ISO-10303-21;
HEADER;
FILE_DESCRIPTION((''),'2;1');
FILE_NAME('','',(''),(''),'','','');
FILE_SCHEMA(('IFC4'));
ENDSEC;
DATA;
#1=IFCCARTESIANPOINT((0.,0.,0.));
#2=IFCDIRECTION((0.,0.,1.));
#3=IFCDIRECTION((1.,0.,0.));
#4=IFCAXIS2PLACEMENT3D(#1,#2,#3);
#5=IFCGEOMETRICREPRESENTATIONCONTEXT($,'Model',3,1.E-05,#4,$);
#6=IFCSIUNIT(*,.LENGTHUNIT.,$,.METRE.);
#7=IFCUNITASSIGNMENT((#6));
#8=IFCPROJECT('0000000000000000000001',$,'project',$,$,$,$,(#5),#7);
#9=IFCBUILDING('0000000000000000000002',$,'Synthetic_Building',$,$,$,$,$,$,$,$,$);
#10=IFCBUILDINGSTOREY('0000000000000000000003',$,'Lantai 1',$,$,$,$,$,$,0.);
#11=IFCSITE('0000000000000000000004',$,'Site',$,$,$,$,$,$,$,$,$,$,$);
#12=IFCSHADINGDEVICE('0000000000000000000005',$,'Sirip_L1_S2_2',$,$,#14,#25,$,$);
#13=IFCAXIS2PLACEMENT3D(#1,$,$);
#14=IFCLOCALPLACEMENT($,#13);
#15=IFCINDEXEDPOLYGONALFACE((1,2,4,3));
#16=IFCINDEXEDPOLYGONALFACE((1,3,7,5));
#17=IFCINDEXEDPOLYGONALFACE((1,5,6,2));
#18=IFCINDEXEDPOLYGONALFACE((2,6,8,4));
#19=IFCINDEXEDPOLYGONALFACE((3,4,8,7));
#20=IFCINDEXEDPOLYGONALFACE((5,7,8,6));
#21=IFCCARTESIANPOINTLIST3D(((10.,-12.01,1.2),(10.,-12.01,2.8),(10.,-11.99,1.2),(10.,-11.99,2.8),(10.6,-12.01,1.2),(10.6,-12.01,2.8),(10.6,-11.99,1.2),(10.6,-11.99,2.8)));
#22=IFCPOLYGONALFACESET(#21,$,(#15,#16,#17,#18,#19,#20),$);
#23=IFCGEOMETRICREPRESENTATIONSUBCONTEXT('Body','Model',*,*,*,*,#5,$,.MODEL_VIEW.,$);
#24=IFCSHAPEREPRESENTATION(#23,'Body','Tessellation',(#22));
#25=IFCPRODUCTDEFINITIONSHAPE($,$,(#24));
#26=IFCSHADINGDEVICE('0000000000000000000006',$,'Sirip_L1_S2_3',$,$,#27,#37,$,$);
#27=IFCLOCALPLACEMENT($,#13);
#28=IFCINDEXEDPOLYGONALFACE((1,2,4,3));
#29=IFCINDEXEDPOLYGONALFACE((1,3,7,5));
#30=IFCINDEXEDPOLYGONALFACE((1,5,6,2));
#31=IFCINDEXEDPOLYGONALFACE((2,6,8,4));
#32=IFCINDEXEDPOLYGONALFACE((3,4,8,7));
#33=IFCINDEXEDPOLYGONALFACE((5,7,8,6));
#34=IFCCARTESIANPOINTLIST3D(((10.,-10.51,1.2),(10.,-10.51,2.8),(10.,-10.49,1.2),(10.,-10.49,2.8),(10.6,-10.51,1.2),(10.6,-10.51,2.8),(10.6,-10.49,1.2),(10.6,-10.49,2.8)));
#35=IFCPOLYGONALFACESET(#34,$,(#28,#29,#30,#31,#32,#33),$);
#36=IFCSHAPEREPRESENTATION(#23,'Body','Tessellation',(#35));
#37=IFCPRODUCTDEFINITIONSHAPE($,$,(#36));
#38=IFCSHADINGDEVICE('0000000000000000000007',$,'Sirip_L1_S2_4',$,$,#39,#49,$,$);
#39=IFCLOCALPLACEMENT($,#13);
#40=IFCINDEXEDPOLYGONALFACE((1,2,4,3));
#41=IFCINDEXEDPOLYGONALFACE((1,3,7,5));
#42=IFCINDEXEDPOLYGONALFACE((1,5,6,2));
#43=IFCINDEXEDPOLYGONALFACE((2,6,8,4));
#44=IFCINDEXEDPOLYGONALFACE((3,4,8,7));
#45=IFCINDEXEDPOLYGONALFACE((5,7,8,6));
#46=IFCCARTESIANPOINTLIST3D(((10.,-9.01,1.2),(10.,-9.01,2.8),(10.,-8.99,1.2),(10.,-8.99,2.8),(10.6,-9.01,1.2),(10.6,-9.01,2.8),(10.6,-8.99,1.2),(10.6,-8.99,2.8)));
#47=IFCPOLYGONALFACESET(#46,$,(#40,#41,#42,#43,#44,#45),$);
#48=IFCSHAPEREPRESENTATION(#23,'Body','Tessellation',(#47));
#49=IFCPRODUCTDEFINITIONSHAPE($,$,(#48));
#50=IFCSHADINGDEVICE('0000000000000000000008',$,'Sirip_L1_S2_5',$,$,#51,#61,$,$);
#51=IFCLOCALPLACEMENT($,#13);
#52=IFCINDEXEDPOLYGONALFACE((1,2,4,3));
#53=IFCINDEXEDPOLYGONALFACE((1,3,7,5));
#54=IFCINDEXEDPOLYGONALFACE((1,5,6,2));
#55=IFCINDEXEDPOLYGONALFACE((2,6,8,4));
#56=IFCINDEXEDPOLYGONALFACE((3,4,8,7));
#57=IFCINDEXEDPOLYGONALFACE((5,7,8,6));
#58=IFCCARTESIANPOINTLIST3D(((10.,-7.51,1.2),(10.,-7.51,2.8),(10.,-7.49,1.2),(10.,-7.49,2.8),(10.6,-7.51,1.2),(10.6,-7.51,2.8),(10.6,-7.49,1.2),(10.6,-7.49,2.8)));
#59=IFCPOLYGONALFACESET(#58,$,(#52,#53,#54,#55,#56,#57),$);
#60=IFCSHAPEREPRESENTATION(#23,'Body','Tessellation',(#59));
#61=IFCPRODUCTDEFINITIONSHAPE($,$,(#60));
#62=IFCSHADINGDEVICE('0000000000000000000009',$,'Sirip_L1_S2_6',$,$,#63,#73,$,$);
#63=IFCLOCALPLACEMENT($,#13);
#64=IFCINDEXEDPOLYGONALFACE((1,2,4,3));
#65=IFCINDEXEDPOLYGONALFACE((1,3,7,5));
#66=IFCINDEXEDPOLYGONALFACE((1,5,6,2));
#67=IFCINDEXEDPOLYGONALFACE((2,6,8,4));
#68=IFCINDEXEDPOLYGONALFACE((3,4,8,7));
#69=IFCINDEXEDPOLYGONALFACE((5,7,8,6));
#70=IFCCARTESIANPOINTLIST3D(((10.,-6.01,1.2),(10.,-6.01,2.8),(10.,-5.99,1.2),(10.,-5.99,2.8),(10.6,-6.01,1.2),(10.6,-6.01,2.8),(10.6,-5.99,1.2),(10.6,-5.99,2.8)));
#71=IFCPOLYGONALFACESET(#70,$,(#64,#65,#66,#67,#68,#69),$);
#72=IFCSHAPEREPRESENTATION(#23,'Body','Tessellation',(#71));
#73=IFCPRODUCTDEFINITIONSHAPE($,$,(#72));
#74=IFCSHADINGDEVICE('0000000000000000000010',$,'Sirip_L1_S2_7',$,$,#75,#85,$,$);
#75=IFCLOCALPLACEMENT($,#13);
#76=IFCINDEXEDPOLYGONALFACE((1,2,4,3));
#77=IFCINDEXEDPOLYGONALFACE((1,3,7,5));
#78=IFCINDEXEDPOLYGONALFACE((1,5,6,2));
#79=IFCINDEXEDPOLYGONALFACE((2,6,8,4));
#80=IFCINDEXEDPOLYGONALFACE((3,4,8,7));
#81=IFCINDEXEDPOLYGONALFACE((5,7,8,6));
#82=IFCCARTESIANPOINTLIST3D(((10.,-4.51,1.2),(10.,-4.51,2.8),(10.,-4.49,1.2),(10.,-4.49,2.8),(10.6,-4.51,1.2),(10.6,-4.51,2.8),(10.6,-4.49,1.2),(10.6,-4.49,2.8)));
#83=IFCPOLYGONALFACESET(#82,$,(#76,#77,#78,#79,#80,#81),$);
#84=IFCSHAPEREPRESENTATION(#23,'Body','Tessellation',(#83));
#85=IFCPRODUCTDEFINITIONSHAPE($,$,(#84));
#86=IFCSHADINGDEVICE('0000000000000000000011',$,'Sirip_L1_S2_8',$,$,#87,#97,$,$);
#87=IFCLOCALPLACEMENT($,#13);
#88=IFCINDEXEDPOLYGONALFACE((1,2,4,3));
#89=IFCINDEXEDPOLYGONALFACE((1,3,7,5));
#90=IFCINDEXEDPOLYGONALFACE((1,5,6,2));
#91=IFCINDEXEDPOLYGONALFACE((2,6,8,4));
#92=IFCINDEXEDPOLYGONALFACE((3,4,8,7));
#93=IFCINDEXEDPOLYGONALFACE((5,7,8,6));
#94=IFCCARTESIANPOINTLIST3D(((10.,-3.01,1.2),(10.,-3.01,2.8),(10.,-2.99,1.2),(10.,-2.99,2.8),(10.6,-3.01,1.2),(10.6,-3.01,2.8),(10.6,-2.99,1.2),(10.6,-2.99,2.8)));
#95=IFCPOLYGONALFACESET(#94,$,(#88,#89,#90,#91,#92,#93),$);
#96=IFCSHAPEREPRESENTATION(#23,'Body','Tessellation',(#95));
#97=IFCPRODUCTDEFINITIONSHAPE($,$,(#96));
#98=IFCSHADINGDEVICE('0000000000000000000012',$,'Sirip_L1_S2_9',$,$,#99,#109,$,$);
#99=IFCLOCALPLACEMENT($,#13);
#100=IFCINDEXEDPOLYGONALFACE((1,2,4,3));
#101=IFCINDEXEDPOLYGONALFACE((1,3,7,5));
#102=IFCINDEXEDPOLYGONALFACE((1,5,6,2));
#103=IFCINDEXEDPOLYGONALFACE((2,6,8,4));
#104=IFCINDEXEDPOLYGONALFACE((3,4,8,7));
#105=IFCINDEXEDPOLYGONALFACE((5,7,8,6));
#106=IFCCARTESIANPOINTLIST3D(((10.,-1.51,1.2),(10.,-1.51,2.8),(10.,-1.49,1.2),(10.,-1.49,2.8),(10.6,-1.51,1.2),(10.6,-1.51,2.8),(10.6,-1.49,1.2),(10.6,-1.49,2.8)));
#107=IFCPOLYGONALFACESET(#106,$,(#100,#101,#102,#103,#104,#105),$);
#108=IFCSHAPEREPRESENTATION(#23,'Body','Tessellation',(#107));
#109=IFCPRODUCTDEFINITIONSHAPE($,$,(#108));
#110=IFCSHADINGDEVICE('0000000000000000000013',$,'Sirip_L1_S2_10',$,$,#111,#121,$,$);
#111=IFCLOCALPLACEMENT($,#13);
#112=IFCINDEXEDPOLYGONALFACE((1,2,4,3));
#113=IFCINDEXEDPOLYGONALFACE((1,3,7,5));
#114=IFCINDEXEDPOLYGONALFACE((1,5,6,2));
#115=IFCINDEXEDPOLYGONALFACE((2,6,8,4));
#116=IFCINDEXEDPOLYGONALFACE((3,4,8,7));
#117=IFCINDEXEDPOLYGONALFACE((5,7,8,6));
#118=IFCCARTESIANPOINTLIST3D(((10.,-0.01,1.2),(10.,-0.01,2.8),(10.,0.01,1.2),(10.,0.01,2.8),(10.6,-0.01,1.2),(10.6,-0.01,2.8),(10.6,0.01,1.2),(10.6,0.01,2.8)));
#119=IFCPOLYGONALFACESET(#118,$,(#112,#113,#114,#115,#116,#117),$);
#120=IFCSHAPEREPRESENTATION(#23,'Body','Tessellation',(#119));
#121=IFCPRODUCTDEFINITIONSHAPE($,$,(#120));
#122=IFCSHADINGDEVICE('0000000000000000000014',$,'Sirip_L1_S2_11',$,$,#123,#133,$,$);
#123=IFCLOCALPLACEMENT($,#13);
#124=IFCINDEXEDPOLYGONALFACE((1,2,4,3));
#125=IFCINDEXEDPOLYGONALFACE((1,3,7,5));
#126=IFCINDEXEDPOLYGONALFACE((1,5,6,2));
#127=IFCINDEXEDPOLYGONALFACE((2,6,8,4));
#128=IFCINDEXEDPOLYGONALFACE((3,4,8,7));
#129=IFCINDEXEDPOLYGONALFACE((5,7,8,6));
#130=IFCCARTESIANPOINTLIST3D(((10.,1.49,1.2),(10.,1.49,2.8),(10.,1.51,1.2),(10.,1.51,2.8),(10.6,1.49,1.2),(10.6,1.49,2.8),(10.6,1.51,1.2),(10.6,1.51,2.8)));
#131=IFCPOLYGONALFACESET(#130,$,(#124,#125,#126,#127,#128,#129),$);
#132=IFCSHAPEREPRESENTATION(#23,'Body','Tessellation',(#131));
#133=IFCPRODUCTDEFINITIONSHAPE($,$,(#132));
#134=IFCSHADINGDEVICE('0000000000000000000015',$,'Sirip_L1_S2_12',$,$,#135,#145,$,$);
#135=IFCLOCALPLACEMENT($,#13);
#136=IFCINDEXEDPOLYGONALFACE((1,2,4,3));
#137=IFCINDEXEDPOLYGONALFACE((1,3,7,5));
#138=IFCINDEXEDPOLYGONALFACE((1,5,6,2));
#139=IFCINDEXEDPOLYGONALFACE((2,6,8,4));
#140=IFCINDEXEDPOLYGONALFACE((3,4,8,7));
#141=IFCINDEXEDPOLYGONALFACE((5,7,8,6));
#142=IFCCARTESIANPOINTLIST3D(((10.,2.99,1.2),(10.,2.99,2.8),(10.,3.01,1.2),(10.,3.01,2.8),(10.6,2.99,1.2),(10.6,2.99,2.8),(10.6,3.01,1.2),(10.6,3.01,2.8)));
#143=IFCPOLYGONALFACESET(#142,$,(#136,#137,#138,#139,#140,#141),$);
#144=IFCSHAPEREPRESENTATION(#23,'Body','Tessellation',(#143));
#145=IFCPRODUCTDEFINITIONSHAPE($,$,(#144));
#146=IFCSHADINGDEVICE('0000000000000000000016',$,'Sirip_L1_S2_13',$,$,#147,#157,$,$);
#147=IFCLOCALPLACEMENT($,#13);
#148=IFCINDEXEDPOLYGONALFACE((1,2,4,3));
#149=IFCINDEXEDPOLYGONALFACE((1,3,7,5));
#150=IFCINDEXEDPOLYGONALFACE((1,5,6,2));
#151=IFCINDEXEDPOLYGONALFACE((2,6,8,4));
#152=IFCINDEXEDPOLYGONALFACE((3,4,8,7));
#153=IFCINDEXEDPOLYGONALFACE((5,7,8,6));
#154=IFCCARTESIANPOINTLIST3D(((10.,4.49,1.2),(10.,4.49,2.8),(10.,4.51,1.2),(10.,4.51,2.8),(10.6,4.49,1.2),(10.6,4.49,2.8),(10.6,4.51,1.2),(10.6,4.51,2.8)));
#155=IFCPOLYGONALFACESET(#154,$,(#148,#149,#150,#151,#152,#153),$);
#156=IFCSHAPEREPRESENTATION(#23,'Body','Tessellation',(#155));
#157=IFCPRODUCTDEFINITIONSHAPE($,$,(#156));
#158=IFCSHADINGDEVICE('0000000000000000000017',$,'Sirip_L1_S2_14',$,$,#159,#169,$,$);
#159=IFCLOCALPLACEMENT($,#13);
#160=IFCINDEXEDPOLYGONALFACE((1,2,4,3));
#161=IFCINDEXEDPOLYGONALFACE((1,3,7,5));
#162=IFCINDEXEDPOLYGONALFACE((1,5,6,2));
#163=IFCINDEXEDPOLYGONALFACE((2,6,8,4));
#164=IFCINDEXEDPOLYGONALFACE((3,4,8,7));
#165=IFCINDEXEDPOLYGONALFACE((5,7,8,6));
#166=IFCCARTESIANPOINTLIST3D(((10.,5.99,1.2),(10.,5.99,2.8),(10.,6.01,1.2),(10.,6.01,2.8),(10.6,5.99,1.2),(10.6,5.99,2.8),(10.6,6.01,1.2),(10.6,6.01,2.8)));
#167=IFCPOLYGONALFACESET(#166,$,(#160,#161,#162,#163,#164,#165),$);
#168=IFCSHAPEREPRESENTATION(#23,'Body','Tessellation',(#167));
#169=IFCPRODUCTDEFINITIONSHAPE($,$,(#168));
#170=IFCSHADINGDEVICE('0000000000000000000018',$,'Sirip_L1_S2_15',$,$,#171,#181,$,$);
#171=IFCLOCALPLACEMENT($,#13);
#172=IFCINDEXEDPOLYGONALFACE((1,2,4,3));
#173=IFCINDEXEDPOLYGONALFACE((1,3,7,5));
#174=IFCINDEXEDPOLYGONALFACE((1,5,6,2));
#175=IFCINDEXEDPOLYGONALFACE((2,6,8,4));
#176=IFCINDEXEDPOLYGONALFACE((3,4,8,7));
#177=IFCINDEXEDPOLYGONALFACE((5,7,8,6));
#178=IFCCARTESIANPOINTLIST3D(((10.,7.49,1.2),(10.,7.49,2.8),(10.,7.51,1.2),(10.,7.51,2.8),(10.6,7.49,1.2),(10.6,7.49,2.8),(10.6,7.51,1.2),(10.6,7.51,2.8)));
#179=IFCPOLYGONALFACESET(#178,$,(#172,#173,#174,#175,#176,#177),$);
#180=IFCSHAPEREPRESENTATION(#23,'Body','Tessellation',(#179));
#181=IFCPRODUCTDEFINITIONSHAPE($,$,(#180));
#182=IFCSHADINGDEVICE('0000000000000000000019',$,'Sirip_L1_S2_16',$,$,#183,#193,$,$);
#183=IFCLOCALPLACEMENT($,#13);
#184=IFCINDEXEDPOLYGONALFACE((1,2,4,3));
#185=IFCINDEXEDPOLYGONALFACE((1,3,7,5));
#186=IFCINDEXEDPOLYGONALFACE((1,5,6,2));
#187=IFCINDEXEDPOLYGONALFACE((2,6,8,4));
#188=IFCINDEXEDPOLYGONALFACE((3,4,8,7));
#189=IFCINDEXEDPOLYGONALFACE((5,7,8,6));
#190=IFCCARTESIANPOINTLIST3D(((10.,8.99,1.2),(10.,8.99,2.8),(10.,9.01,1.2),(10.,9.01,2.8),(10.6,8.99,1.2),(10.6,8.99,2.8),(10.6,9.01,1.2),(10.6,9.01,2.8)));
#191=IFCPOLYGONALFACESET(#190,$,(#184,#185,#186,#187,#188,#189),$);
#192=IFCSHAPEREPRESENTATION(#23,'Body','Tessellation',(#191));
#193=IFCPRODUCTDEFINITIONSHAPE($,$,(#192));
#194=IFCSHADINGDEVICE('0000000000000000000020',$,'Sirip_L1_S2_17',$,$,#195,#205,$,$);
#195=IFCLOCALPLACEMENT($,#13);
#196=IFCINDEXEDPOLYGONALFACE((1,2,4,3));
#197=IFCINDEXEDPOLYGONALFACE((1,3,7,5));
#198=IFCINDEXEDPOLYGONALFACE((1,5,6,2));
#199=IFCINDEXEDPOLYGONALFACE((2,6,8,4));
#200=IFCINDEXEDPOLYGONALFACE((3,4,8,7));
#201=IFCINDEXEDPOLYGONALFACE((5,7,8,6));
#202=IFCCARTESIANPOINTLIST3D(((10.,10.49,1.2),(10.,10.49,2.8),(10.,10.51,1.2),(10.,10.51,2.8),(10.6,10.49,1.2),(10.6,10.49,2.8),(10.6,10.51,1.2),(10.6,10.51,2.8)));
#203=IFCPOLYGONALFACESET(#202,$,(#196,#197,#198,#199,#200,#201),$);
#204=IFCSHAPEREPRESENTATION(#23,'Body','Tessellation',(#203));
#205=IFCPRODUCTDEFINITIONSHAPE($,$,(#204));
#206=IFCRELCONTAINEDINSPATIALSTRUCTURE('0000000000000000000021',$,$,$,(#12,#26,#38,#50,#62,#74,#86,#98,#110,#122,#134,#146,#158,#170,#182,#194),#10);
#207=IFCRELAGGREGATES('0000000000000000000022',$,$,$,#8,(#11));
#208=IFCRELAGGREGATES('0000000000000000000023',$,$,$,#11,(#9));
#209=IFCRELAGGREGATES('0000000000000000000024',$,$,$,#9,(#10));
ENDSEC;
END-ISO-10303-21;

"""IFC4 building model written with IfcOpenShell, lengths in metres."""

from ifc_helpers import new_model, si_unit, frame, origin_with_axes, place, context, subcontext, project, spatial, polyline, outline, extrude, element, save


model = new_model("IFC4")

# Units and contexts
model_context = context("Model", 3, precision=1e-05, world=origin_with_axes())
body_context = subcontext(model_context, "Body", "Model", "MODEL_VIEW")
ifc_project = project(units=[si_unit("LENGTHUNIT", "METRE")], contexts=[model_context])

# Site, building, storey
site = spatial("IfcSite", under=ifc_project, Name="Site")
building = spatial("IfcBuilding", under=site, Name="Synthetic_Building")
storey = spatial("IfcBuildingStorey", under=building, Name="Lantai 1", Elevation=0.0)

# Shading devices
shading_device_1_placement = place(None, origin_with_axes())
element("IfcShadingDevice", 1, at=shading_device_1_placement, inside=storey, Name="Sirip_L1_S2_2", context=body_context, shape_type="SweptSolid", body=[
    extrude(outline(polyline([(10.0, -12.01), (10.0, -11.99), (10.6, -11.99), (10.6, -12.01), (10.0, -12.01)])), frame((0.0, 0.0, 1.2), z_axis=(0.0, 0.0, 1.0), x_axis=(1.0, 0.0, 0.0)), (0.0, 0.0, 1.0), 1.6),
])
shading_device_2_placement = place(None, origin_with_axes())
element("IfcShadingDevice", 2, at=shading_device_2_placement, inside=storey, Name="Sirip_L1_S2_3", context=body_context, shape_type="SweptSolid", body=[
    extrude(outline(polyline([(10.0, -10.51), (10.0, -10.49), (10.6, -10.49), (10.6, -10.51), (10.0, -10.51)])), frame((0.0, 0.0, 1.2), z_axis=(0.0, 0.0, 1.0), x_axis=(1.0, 0.0, 0.0)), (0.0, 0.0, 1.0), 1.6),
])
shading_device_3_placement = place(None, origin_with_axes())
element("IfcShadingDevice", 3, at=shading_device_3_placement, inside=storey, Name="Sirip_L1_S2_4", context=body_context, shape_type="SweptSolid", body=[
    extrude(outline(polyline([(10.0, -9.01), (10.0, -8.99), (10.6, -8.99), (10.6, -9.01), (10.0, -9.01)])), frame((0.0, 0.0, 1.2), z_axis=(0.0, 0.0, 1.0), x_axis=(1.0, 0.0, 0.0)), (0.0, 0.0, 1.0), 1.6),
])
shading_device_4_placement = place(None, origin_with_axes())
element("IfcShadingDevice", 4, at=shading_device_4_placement, inside=storey, Name="Sirip_L1_S2_5", context=body_context, shape_type="SweptSolid", body=[
    extrude(outline(polyline([(10.0, -7.51), (10.0, -7.49), (10.6, -7.49), (10.6, -7.51), (10.0, -7.51)])), frame((0.0, 0.0, 1.2), z_axis=(0.0, 0.0, 1.0), x_axis=(1.0, 0.0, 0.0)), (0.0, 0.0, 1.0), 1.6),
])
shading_device_5_placement = place(None, origin_with_axes())
element("IfcShadingDevice", 5, at=shading_device_5_placement, inside=storey, Name="Sirip_L1_S2_6", context=body_context, shape_type="SweptSolid", body=[
    extrude(outline(polyline([(10.0, -6.01), (10.0, -5.99), (10.6, -5.99), (10.6, -6.01), (10.0, -6.01)])), frame((0.0, 0.0, 1.2), z_axis=(0.0, 0.0, 1.0), x_axis=(1.0, 0.0, 0.0)), (0.0, 0.0, 1.0), 1.6),
])
shading_device_6_placement = place(None, origin_with_axes())
element("IfcShadingDevice", 6, at=shading_device_6_placement, inside=storey, Name="Sirip_L1_S2_7", context=body_context, shape_type="SweptSolid", body=[
    extrude(outline(polyline([(10.0, -4.51), (10.0, -4.49), (10.6, -4.49), (10.6, -4.51), (10.0, -4.51)])), frame((0.0, 0.0, 1.2), z_axis=(0.0, 0.0, 1.0), x_axis=(1.0, 0.0, 0.0)), (0.0, 0.0, 1.0), 1.6),
])
shading_device_7_placement = place(None, origin_with_axes())
element("IfcShadingDevice", 7, at=shading_device_7_placement, inside=storey, Name="Sirip_L1_S2_8", context=body_context, shape_type="SweptSolid", body=[
    extrude(outline(polyline([(10.0, -3.01), (10.0, -2.99), (10.6, -2.99), (10.6, -3.01), (10.0, -3.01)])), frame((0.0, 0.0, 1.2), z_axis=(0.0, 0.0, 1.0), x_axis=(1.0, 0.0, 0.0)), (0.0, 0.0, 1.0), 1.6),
])
shading_device_8_placement = place(None, origin_with_axes())
element("IfcShadingDevice", 8, at=shading_device_8_placement, inside=storey, Name="Sirip_L1_S2_9", context=body_context, shape_type="SweptSolid", body=[
    extrude(outline(polyline([(10.0, -1.51), (10.0, -1.49), (10.6, -1.49), (10.6, -1.51), (10.0, -1.51)])), frame((0.0, 0.0, 1.2), z_axis=(0.0, 0.0, 1.0), x_axis=(1.0, 0.0, 0.0)), (0.0, 0.0, 1.0), 1.6),
])
shading_device_9_placement = place(None, origin_with_axes())
element("IfcShadingDevice", 9, at=shading_device_9_placement, inside=storey, Name="Sirip_L1_S2_10", context=body_context, shape_type="SweptSolid", body=[
    extrude(outline(polyline([(10.0, -0.01), (10.0, 0.01), (10.6, 0.01), (10.6, -0.01), (10.0, -0.01)])), frame((0.0, 0.0, 1.2), z_axis=(0.0, 0.0, 1.0), x_axis=(1.0, 0.0, 0.0)), (0.0, 0.0, 1.0), 1.6),
])
shading_device_10_placement = place(None, origin_with_axes())
element("IfcShadingDevice", 10, at=shading_device_10_placement, inside=storey, Name="Sirip_L1_S2_11", context=body_context, shape_type="SweptSolid", body=[
    extrude(outline(polyline([(10.0, 1.49), (10.0, 1.51), (10.6, 1.51), (10.6, 1.49), (10.0, 1.49)])), frame((0.0, 0.0, 1.2), z_axis=(0.0, 0.0, 1.0), x_axis=(1.0, 0.0, 0.0)), (0.0, 0.0, 1.0), 1.6),
])
shading_device_11_placement = place(None, origin_with_axes())
element("IfcShadingDevice", 11, at=shading_device_11_placement, inside=storey, Name="Sirip_L1_S2_12", context=body_context, shape_type="SweptSolid", body=[
    extrude(outline(polyline([(10.0, 2.99), (10.0, 3.01), (10.6, 3.01), (10.6, 2.99), (10.0, 2.99)])), frame((0.0, 0.0, 1.2), z_axis=(0.0, 0.0, 1.0), x_axis=(1.0, 0.0, 0.0)), (0.0, 0.0, 1.0), 1.6),
])
shading_device_12_placement = place(None, origin_with_axes())
element("IfcShadingDevice", 12, at=shading_device_12_placement, inside=storey, Name="Sirip_L1_S2_13", context=body_context, shape_type="SweptSolid", body=[
    extrude(outline(polyline([(10.0, 4.49), (10.0, 4.51), (10.6, 4.51), (10.6, 4.49), (10.0, 4.49)])), frame((0.0, 0.0, 1.2), z_axis=(0.0, 0.0, 1.0), x_axis=(1.0, 0.0, 0.0)), (0.0, 0.0, 1.0), 1.6),
])
shading_device_13_placement = place(None, origin_with_axes())
element("IfcShadingDevice", 13, at=shading_device_13_placement, inside=storey, Name="Sirip_L1_S2_14", context=body_context, shape_type="SweptSolid", body=[
    extrude(outline(polyline([(10.0, 5.99), (10.0, 6.01), (10.6, 6.01), (10.6, 5.99), (10.0, 5.99)])), frame((0.0, 0.0, 1.2), z_axis=(0.0, 0.0, 1.0), x_axis=(1.0, 0.0, 0.0)), (0.0, 0.0, 1.0), 1.6),
])
shading_device_14_placement = place(None, origin_with_axes())
element("IfcShadingDevice", 14, at=shading_device_14_placement, inside=storey, Name="Sirip_L1_S2_15", context=body_context, shape_type="SweptSolid", body=[
    extrude(outline(polyline([(10.0, 7.49), (10.0, 7.51), (10.6, 7.51), (10.6, 7.49), (10.0, 7.49)])), frame((0.0, 0.0, 1.2), z_axis=(0.0, 0.0, 1.0), x_axis=(1.0, 0.0, 0.0)), (0.0, 0.0, 1.0), 1.6),
])
shading_device_15_placement = place(None, origin_with_axes())
element("IfcShadingDevice", 15, at=shading_device_15_placement, inside=storey, Name="Sirip_L1_S2_16", context=body_context, shape_type="SweptSolid", body=[
    extrude(outline(polyline([(10.0, 8.99), (10.0, 9.01), (10.6, 9.01), (10.6, 8.99), (10.0, 8.99)])), frame((0.0, 0.0, 1.2), z_axis=(0.0, 0.0, 1.0), x_axis=(1.0, 0.0, 0.0)), (0.0, 0.0, 1.0), 1.6),
])
shading_device_16_placement = place(None, origin_with_axes())
element("IfcShadingDevice", 16, at=shading_device_16_placement, inside=storey, Name="Sirip_L1_S2_17", context=body_context, shape_type="SweptSolid", body=[
    extrude(outline(polyline([(10.0, 10.49), (10.0, 10.51), (10.6, 10.51), (10.6, 10.49), (10.0, 10.49)])), frame((0.0, 0.0, 1.2), z_axis=(0.0, 0.0, 1.0), x_axis=(1.0, 0.0, 0.0)), (0.0, 0.0, 1.0), 1.6),
])

save(model, "model.ifc")
